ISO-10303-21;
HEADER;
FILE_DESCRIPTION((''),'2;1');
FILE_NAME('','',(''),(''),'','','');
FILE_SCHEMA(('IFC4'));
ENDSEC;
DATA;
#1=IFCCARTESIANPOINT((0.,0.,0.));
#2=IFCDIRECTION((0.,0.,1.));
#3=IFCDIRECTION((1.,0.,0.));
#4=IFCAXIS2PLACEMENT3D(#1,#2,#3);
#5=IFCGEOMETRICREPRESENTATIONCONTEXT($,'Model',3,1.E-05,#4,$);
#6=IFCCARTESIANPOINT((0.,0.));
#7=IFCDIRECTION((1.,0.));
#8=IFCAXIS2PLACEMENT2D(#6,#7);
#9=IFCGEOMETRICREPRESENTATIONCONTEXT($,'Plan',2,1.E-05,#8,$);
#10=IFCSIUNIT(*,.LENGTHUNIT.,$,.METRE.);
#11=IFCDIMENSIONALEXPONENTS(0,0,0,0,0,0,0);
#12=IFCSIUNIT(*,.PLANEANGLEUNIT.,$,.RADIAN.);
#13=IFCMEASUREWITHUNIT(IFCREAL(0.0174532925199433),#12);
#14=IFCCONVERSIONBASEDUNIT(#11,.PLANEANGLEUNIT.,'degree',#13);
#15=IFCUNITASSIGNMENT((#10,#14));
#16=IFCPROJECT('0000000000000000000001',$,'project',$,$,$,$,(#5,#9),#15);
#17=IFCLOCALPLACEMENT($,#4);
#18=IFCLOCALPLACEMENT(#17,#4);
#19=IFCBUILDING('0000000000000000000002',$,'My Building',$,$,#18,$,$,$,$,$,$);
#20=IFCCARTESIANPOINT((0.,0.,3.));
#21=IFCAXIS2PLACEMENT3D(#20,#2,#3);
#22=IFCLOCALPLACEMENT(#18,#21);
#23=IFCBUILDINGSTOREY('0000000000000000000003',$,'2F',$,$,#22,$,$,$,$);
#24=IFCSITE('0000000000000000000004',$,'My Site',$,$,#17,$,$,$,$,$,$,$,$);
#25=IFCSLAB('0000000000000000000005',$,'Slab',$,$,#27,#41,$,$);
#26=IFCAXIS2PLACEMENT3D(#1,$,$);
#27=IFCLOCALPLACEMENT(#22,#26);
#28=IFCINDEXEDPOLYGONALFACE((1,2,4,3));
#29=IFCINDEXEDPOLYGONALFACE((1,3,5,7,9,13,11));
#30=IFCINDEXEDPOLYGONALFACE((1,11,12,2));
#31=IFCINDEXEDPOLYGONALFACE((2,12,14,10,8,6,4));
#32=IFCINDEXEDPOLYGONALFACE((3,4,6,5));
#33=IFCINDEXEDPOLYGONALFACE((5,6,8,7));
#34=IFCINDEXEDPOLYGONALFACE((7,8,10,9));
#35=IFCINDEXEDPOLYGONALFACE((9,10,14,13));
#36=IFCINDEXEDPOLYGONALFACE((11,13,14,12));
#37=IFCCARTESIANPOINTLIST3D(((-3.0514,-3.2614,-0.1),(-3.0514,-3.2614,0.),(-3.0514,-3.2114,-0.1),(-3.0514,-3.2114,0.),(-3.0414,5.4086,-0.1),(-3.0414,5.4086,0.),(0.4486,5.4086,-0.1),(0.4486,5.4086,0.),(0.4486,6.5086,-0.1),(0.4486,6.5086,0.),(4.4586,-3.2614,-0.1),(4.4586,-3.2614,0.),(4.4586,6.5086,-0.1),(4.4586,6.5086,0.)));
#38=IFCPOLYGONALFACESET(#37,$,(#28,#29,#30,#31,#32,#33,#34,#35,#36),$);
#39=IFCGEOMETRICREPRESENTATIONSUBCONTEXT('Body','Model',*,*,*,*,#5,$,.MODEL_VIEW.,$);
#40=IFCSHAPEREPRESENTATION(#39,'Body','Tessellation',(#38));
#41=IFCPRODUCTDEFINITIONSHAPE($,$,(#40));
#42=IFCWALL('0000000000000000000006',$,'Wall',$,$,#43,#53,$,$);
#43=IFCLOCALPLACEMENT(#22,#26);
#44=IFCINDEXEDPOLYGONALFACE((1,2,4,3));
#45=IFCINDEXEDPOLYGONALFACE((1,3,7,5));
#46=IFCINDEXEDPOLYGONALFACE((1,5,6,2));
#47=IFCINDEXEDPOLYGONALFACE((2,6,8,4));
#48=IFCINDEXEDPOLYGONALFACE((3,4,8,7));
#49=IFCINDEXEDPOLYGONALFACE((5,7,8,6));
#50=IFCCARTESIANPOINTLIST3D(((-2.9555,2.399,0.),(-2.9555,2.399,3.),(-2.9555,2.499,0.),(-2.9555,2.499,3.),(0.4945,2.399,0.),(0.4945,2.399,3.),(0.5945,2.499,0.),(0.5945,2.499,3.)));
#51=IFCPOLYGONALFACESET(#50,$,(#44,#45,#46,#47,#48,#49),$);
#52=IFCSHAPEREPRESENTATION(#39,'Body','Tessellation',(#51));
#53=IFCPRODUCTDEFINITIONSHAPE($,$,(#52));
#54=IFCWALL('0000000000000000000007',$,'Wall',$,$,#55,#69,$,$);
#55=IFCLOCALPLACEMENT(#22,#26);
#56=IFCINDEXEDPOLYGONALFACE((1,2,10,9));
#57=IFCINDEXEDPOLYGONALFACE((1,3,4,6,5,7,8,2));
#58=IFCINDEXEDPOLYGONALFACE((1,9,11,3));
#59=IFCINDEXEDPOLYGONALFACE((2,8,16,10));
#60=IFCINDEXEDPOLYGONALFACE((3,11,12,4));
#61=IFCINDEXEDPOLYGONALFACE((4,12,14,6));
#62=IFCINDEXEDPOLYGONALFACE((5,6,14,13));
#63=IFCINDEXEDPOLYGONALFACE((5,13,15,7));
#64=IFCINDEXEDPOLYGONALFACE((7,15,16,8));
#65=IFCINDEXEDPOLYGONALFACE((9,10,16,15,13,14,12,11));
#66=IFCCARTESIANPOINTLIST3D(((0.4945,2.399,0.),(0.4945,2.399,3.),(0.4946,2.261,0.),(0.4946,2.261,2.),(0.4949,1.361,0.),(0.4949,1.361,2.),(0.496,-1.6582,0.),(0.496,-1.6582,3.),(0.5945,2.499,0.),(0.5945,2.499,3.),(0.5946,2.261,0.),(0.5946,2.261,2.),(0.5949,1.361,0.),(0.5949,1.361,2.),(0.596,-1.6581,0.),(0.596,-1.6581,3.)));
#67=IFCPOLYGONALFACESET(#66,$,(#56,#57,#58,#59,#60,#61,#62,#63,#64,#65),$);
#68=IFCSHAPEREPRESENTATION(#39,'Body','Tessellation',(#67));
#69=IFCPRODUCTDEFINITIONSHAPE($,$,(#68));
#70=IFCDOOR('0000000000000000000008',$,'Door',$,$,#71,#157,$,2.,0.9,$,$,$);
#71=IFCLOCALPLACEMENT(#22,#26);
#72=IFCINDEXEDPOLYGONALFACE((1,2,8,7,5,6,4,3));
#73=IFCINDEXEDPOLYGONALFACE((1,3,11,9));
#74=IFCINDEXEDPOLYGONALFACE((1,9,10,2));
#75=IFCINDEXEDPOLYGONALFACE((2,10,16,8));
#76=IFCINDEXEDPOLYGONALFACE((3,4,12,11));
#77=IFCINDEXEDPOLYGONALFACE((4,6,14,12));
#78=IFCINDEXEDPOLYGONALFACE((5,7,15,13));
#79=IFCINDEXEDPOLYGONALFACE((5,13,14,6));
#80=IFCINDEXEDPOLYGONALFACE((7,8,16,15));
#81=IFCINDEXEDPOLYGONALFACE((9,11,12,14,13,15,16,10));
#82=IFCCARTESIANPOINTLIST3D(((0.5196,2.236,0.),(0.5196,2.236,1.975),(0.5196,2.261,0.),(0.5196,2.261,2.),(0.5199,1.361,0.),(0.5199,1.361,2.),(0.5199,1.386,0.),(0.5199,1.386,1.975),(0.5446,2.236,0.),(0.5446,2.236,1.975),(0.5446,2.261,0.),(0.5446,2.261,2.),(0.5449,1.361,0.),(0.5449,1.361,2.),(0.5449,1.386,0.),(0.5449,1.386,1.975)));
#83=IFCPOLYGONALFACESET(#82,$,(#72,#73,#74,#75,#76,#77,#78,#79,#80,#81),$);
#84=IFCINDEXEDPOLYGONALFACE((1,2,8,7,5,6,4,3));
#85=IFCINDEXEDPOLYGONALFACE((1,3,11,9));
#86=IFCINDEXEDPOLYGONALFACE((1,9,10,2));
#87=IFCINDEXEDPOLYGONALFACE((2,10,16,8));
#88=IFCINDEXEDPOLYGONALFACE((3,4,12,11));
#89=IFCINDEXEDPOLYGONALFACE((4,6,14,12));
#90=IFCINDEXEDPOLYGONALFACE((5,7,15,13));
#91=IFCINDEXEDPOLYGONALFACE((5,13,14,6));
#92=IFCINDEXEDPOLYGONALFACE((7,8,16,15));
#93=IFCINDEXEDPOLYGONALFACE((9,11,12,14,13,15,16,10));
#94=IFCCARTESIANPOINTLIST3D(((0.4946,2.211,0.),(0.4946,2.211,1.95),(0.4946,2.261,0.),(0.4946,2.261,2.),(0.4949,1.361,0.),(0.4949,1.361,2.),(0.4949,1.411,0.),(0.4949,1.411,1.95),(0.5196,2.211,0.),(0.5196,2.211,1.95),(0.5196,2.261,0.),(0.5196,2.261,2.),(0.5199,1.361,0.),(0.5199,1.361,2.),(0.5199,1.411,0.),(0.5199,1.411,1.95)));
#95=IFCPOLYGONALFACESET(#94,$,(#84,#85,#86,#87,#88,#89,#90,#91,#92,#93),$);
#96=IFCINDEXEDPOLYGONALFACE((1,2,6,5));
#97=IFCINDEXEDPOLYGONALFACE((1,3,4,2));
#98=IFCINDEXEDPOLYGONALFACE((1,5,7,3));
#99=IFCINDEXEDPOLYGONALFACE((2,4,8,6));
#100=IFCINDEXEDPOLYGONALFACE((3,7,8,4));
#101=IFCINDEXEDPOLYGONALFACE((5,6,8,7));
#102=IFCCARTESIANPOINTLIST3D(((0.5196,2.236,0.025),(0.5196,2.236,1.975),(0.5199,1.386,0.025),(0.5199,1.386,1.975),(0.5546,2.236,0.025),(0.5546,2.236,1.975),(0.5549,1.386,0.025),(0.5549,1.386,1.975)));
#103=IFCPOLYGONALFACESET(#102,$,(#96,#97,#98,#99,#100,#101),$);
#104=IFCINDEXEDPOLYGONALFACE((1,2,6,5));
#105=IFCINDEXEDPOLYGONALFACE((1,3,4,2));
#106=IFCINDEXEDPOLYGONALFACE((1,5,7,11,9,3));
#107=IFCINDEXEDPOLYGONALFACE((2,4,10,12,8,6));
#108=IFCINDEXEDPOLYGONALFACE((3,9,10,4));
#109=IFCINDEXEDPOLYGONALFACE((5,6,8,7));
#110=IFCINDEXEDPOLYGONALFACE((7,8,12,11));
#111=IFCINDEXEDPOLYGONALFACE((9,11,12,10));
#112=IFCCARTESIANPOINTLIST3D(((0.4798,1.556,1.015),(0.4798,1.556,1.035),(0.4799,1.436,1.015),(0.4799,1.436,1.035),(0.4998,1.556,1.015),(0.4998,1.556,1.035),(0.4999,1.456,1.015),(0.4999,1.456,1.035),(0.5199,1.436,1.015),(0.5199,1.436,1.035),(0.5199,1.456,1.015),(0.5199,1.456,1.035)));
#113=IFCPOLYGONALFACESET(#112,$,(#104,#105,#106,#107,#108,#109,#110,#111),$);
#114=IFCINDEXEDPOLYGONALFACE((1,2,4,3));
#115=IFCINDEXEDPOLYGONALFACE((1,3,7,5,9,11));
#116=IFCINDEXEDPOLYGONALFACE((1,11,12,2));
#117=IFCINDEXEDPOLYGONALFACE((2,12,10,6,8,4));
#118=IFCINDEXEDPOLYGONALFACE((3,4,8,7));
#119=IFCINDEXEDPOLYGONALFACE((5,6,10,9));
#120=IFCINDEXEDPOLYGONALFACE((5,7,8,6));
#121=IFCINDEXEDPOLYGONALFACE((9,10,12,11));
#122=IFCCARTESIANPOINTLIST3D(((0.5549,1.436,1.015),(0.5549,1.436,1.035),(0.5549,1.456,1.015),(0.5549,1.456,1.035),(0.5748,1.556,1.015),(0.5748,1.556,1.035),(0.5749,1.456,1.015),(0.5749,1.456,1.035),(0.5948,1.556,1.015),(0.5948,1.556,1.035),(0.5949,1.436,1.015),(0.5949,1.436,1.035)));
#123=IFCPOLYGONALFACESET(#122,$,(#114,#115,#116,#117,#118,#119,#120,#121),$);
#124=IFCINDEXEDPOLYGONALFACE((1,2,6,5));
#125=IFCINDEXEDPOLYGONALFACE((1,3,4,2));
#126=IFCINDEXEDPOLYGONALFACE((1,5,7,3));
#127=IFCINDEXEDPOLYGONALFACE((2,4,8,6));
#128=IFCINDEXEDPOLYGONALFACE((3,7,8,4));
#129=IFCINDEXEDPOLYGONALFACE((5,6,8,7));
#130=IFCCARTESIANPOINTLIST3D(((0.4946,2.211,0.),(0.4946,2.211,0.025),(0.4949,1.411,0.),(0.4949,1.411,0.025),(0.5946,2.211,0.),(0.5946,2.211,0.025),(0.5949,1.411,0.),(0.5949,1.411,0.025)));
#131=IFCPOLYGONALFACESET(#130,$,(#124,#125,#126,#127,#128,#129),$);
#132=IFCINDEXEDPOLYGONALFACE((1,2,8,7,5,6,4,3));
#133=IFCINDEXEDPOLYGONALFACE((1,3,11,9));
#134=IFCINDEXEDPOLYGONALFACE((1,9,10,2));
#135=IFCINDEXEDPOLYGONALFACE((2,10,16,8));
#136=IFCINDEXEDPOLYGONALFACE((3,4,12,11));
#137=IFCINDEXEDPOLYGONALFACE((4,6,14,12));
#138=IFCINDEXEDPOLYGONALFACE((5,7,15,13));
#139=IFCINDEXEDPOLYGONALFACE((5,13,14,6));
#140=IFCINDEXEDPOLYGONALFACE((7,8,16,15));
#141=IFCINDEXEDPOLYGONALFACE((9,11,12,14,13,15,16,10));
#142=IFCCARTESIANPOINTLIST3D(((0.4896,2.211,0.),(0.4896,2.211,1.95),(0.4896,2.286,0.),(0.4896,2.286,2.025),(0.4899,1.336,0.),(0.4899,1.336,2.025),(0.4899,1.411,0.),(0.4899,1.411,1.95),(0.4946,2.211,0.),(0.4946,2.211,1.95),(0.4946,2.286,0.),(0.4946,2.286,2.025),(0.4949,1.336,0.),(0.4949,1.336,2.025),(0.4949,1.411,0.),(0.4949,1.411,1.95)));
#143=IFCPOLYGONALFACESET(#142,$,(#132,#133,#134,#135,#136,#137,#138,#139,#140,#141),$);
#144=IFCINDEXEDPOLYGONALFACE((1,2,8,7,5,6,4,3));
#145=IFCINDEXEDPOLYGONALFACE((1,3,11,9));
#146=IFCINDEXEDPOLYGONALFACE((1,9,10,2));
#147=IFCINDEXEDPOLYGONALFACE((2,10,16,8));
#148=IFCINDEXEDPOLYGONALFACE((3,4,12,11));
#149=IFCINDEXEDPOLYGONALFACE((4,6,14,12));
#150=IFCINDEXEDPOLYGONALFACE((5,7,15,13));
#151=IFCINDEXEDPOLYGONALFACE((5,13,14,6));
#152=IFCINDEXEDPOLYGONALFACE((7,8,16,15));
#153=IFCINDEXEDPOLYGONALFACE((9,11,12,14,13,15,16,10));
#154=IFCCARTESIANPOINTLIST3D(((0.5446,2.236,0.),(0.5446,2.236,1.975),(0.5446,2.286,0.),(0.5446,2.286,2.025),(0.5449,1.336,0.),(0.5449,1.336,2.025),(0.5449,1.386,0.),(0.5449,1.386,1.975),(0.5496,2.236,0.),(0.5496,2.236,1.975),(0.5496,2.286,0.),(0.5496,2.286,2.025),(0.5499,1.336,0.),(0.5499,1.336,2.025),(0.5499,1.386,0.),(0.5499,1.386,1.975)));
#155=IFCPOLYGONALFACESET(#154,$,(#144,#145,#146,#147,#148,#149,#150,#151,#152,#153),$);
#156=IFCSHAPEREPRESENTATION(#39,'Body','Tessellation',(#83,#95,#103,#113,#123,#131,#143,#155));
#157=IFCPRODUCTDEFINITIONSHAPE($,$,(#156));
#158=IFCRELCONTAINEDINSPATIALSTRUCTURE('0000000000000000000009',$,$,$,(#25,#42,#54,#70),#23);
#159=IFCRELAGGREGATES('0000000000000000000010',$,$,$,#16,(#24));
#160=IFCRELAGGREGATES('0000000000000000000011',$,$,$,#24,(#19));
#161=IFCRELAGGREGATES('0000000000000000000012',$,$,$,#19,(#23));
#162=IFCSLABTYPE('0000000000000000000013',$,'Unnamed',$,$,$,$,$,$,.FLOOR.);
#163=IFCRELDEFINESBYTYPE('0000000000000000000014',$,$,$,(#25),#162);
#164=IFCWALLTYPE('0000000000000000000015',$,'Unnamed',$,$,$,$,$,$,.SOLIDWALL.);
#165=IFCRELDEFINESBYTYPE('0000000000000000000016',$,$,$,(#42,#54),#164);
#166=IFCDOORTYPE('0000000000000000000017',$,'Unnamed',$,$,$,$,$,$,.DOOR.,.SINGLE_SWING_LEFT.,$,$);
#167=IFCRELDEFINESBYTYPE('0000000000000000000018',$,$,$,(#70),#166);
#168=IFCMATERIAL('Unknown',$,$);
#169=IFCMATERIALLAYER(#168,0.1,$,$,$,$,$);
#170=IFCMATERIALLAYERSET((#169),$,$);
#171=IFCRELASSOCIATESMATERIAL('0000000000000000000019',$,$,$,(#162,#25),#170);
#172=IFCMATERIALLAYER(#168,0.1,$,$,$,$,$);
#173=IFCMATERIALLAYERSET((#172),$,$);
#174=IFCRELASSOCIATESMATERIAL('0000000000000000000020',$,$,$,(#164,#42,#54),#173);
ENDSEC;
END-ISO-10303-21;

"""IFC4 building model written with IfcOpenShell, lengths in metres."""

from ifc_helpers import new_model, entity, si_unit, converted_unit, frame, origin_with_axes, origin_2d_with_axis, place, context, subcontext, project, spatial, line, indexed_curve, outline, extrude, shape, source, transform, mapped, material, layer, layer_set, layer_usage, type_object, type_shapes, element, fill, save


model = new_model("IFC4")

# Units and contexts
model_context = context("Model", 3, precision=1e-05, world=origin_with_axes())
plan_context = context("Plan", 2, precision=1e-05, world=origin_2d_with_axis())
body_context_1 = subcontext(model_context, "Body", "Model", "MODEL_VIEW")
body_context_2 = subcontext(plan_context, "Body", "Plan", "PLAN_VIEW")
ifc_project = project(units=[si_unit("LENGTHUNIT", "METRE"), converted_unit("PLANEANGLEUNIT", "degree", entity("IfcReal", 0.0174532925199433), si_unit("PLANEANGLEUNIT", "RADIAN"), dimensions=[0, 0, 0, 0, 0, 0, 0])], contexts=[model_context, plan_context])

# Site, building, storey
site_placement = place(None, origin_with_axes())
site = spatial("IfcSite", under=ifc_project, at=site_placement, Name="My Site")
building_placement = place(site_placement, origin_with_axes())
building = spatial("IfcBuilding", under=site, at=building_placement, Name="My Building")
storey_placement = place(building_placement, frame((0.0, 0.0, 3.0), z_axis=(0.0, 0.0, 1.0), x_axis=(1.0, 0.0, 0.0)))
storey = spatial("IfcBuildingStorey", under=building, at=storey_placement, Name="2F")

# Slab
ifc_material = material(Name="Unknown")
ifc_layer_1 = layer(ifc_material, 0.1)
ifc_layer_set_1 = layer_set([ifc_layer_1])
ifc_layer_usage_1 = layer_usage(ifc_layer_set_1, "AXIS3", "POSITIVE", -0.1)
slab_type = type_object("IfcSlabType", Name="Unnamed", PredefinedType="FLOOR", material=ifc_layer_set_1)
slab_placement = place(storey_placement, frame((-3.0514, -3.2114, 0.0), z_axis=(0.0, 0.0, 1.0), x_axis=(1.0, 0.0, 0.0)))
element("IfcSlab", 1, at=slab_placement, inside=storey, type_object=slab_type, material=ifc_layer_usage_1, Name="Slab", context=body_context_1, shape_type="SweptSolid", body=[
    extrude(outline(indexed_curve([(0.0, 0.0), (0.0, -0.05), (7.51, -0.05), (7.51, 9.72), (3.5, 9.72), (3.5, 8.62), (0.01, 8.62), (0.0, 0.0)])), frame((0.0, 0.0, -0.1), z_axis=(0.0, 0.0, 1.0), x_axis=(1.0, 0.0, 0.0)), (0.0, 0.0, 1.0), 0.1),
])

# Wall
ifc_layer_2 = layer(ifc_material, 0.1)
ifc_layer_set_2 = layer_set([ifc_layer_2])
ifc_layer_usage_2 = layer_usage(ifc_layer_set_2, "AXIS2", "POSITIVE", 0.0)
wall_type = type_object("IfcWallType", Name="Unnamed", PredefinedType="SOLIDWALL", material=ifc_layer_set_2)
wall_1_placement = place(storey_placement, frame((-2.9555, 2.399, 0.0), z_axis=(0.0, 0.0, 1.0), x_axis=(1.0, 0.0, 0.0)))
element("IfcWall", 2, at=wall_1_placement, inside=storey, type_object=wall_type, material=ifc_layer_usage_2, Name="Wall", context=body_context_1, shape_type="SweptSolid", body=[
    extrude(outline(indexed_curve([(0.0, 0.0), (0.0, 0.1), (3.55, 0.1), (3.45, 0.0)], segments=[line(1, 2, 3, 4, 1)])), origin_with_axes(), (0.0, 0.0, 1.0), 3.0),
])

# Wall, opening, door
ifc_layer_usage_3 = layer_usage(ifc_layer_set_2, "AXIS2", "POSITIVE", 0.0)
wall_2_placement = place(storey_placement, frame((0.4945, 2.399, 0.0), z_axis=(0.0, 0.0, 1.0), x_axis=(0.000374, -1.0, 0.0)))
wall_2 = element("IfcWall", 3, at=wall_2_placement, inside=storey, type_object=wall_type, material=ifc_layer_usage_3, Name="Wall", context=body_context_1, shape_type="SweptSolid", body=[
    extrude(outline(indexed_curve([(0.0, 0.0), (-0.1, 0.1), (4.0571, 0.1), (4.0571, 0.0)], segments=[line(1, 2, 3, 4, 1)])), origin_with_axes(), (0.0, 0.0, 1.0), 3.0),
])
shared_shape_1 = source(origin_with_axes(), body_context_1, "Body", "SweptSolid", [
    extrude(outline(indexed_curve([(0.0, 0.0), (0.9, 0.0), (0.9, 2.0), (0.0, 2.0)], segments=[line(1, 2, 3, 4, 1)])), frame((0.0, -0.6, 0.0), z_axis=(0.0, -1.0, 0.0), x_axis=(1.0, 0.0, 0.0)), (0.0, 0.0, -1.0), 1.2),
])
opening_1_placement = place(wall_2_placement, frame((0.138, 0.0, 0.0), z_axis=(0.0, 0.0, 1.0), x_axis=(1.0, 0.0, 0.0)))
opening_1 = element("IfcOpeningElement", 4, at=opening_1_placement, cuts=wall_2, PredefinedType="OPENING", context=body_context_1, shape_type="MappedRepresentation", body=[
    mapped(shared_shape_1, transform((0.0, 0.0, 0.0), x_axis=(1.0, 0.0, 0.0), y_axis=(0.0, 1.0, 0.0), z_axis=(0.0, 0.0, 1.0), scale=1.0)),
])
door_type_1 = type_object("IfcDoorType", Name="Unnamed", OperationType="SINGLE_SWING_LEFT", PredefinedType="DOOR")
shared_shape_2 = source(origin_with_axes(), body_context_1, "Body", "SweptSolid", [
    extrude(outline(indexed_curve([(0.0, 0.0), (0.0, 2.0), (0.9, 2.0), (0.9, 0.0), (0.875, 0.0), (0.875, 1.975), (0.025, 1.975), (0.025, 0.0)], segments=[line(1, 2, 3, 4, 5, 6, 7, 8, 1)])), frame((0.0, 0.025, 0.0), z_axis=(0.0, -1.0, 0.0), x_axis=(1.0, 0.0, 0.0)), (0.0, 0.0, -1.0), 0.025),
    extrude(outline(indexed_curve([(0.0, 0.0), (0.0, 2.0), (0.9, 2.0), (0.9, 0.0), (0.85, 0.0), (0.85, 1.95), (0.05, 1.95), (0.05, 0.0)], segments=[line(1, 2, 3, 4, 5, 6, 7, 8, 1)])), frame((0.0, 0.0, 0.0), z_axis=(0.0, -1.0, 0.0), x_axis=(1.0, 0.0, 0.0)), (0.0, 0.0, -1.0), 0.025),
    extrude(outline(indexed_curve([(0.0, 0.0), (0.85, 0.0), (0.85, 0.035), (0.0, 0.035)], segments=[line(1, 2, 3, 4, 1)])), frame((0.025, 0.025, 0.025), z_axis=(0.0, 0.0, 1.0), x_axis=(1.0, 0.0, 0.0)), (0.0, 0.0, 1.0), 1.95),
    extrude(outline(indexed_curve([(0.0, 0.0), (0.0, -0.04), (-0.12, -0.04), (-0.12, -0.02), (-0.02, -0.02), (-0.02, 0.0)], segments=[line(1, 2, 3, 4, 5, 6, 1)])), frame((0.825, 0.025, 1.015), z_axis=(0.0, 0.0, 1.0), x_axis=(1.0, 0.0, 0.0)), (0.0, 0.0, 1.0), 0.02),
    extrude(outline(indexed_curve([(0.0, 0.0), (0.0, 0.04), (-0.12, 0.04), (-0.12, 0.02), (-0.02, 0.02), (-0.02, 0.0)], segments=[line(1, 2, 3, 4, 5, 6, 1)])), frame((0.825, 0.06, 1.015), z_axis=(0.0, 0.0, 1.0), x_axis=(1.0, 0.0, 0.0)), (0.0, 0.0, 1.0), 0.02),
    extrude(outline(indexed_curve([(0.0, 0.0), (0.8, 0.0), (0.8, 0.1), (0.0, 0.1)], segments=[line(1, 2, 3, 4, 1)])), frame((0.05, 0.0, 0.0), z_axis=(0.0, 0.0, 1.0), x_axis=(1.0, 0.0, 0.0)), (0.0, 0.0, 1.0), 0.025),
    extrude(outline(indexed_curve([(0.0, 0.0), (0.0, 2.025), (0.95, 2.025), (0.95, 0.0), (0.875, 0.0), (0.875, 1.95), (0.075, 1.95), (0.075, 0.0)], segments=[line(1, 2, 3, 4, 5, 6, 7, 8, 1)])), frame((-0.025, -0.005, 0.0), z_axis=(0.0, -1.0, 0.0), x_axis=(1.0, 0.0, 0.0)), (0.0, 0.0, -1.0), 0.005),
    extrude(outline(indexed_curve([(0.0, 0.0), (0.0, 2.025), (0.95, 2.025), (0.95, 0.0), (0.9, 0.0), (0.9, 1.975), (0.05, 1.975), (0.05, 0.0)], segments=[line(1, 2, 3, 4, 5, 6, 7, 8, 1)])), frame((-0.025, 0.05, 0.0), z_axis=(0.0, -1.0, 0.0), x_axis=(1.0, 0.0, 0.0)), (0.0, 0.0, -1.0), 0.005),
])
shared_shape_3 = source(origin_with_axes(), body_context_2, "Body", "Curve2D", [
    entity("IfcIndexedPolyCurve", entity("IfcCartesianPointList2D", [[0.0, 0.0], [0.0, 0.05], [0.025, 0.05], [0.025, 0.025], [0.05, 0.025], [0.05, 0.0]]), [entity("IfcLineIndex", [1, 2, 3, 4, 5, 6, 1])]),
    entity("IfcIndexedPolyCurve", entity("IfcCartesianPointList2D", [[0.9, 0.0], [0.9, 0.05], [0.875, 0.05], [0.875, 0.025], [0.85, 0.025], [0.85, 0.0]]), [entity("IfcLineIndex", [1, 2, 3, 4, 5, 6, 1])]),
    entity("IfcTrimmedCurve", entity("IfcEllipse", entity("IfcAxis2Placement2D", entity("IfcCartesianPoint", [0.06, 0.05]), entity("IfcDirection", [1.0, 0.0])), 0.815, 0.85), [entity("IfcCartesianPoint", [0.875, 0.05])], [entity("IfcCartesianPoint", [0.06, 0.9])], True, "CARTESIAN"),
    entity("IfcIndexedPolyCurve", entity("IfcCartesianPointList2D", [[0.025, 0.05], [0.06, 0.05], [0.06, 0.9], [0.025, 0.9]]), [entity("IfcLineIndex", [1, 2, 3, 4, 1])]),
])
type_shapes(door_type_1, [shared_shape_2, shared_shape_3])
door_1_placement = place(opening_1_placement, frame((0.0, 0.0, 0.0), z_axis=(0.0, 0.0, 1.0), x_axis=(1.0, 0.0, 0.0)))
door_1 = element("IfcDoor", 5, at=door_1_placement, inside=storey, type_object=door_type_1, Name="Door", OverallHeight=2.0, OverallWidth=0.9, shapes=[
    shape(body_context_1, "Body", "MappedRepresentation", [mapped(shared_shape_2, transform((0.0, 0.0, 0.0), x_axis=(1.0, 0.0, 0.0), y_axis=(0.0, 1.0, 0.0), z_axis=(0.0, 0.0, 1.0), scale=1.0))]),
    shape(body_context_2, "Body", "MappedRepresentation", [mapped(shared_shape_3, transform((0.0, 0.0, 0.0), x_axis=(1.0, 0.0, 0.0), y_axis=(0.0, 1.0, 0.0), z_axis=(0.0, 0.0, 1.0), scale=1.0))]),
])
fill(opening_1, door_1)

save(model, "model.ifc")
